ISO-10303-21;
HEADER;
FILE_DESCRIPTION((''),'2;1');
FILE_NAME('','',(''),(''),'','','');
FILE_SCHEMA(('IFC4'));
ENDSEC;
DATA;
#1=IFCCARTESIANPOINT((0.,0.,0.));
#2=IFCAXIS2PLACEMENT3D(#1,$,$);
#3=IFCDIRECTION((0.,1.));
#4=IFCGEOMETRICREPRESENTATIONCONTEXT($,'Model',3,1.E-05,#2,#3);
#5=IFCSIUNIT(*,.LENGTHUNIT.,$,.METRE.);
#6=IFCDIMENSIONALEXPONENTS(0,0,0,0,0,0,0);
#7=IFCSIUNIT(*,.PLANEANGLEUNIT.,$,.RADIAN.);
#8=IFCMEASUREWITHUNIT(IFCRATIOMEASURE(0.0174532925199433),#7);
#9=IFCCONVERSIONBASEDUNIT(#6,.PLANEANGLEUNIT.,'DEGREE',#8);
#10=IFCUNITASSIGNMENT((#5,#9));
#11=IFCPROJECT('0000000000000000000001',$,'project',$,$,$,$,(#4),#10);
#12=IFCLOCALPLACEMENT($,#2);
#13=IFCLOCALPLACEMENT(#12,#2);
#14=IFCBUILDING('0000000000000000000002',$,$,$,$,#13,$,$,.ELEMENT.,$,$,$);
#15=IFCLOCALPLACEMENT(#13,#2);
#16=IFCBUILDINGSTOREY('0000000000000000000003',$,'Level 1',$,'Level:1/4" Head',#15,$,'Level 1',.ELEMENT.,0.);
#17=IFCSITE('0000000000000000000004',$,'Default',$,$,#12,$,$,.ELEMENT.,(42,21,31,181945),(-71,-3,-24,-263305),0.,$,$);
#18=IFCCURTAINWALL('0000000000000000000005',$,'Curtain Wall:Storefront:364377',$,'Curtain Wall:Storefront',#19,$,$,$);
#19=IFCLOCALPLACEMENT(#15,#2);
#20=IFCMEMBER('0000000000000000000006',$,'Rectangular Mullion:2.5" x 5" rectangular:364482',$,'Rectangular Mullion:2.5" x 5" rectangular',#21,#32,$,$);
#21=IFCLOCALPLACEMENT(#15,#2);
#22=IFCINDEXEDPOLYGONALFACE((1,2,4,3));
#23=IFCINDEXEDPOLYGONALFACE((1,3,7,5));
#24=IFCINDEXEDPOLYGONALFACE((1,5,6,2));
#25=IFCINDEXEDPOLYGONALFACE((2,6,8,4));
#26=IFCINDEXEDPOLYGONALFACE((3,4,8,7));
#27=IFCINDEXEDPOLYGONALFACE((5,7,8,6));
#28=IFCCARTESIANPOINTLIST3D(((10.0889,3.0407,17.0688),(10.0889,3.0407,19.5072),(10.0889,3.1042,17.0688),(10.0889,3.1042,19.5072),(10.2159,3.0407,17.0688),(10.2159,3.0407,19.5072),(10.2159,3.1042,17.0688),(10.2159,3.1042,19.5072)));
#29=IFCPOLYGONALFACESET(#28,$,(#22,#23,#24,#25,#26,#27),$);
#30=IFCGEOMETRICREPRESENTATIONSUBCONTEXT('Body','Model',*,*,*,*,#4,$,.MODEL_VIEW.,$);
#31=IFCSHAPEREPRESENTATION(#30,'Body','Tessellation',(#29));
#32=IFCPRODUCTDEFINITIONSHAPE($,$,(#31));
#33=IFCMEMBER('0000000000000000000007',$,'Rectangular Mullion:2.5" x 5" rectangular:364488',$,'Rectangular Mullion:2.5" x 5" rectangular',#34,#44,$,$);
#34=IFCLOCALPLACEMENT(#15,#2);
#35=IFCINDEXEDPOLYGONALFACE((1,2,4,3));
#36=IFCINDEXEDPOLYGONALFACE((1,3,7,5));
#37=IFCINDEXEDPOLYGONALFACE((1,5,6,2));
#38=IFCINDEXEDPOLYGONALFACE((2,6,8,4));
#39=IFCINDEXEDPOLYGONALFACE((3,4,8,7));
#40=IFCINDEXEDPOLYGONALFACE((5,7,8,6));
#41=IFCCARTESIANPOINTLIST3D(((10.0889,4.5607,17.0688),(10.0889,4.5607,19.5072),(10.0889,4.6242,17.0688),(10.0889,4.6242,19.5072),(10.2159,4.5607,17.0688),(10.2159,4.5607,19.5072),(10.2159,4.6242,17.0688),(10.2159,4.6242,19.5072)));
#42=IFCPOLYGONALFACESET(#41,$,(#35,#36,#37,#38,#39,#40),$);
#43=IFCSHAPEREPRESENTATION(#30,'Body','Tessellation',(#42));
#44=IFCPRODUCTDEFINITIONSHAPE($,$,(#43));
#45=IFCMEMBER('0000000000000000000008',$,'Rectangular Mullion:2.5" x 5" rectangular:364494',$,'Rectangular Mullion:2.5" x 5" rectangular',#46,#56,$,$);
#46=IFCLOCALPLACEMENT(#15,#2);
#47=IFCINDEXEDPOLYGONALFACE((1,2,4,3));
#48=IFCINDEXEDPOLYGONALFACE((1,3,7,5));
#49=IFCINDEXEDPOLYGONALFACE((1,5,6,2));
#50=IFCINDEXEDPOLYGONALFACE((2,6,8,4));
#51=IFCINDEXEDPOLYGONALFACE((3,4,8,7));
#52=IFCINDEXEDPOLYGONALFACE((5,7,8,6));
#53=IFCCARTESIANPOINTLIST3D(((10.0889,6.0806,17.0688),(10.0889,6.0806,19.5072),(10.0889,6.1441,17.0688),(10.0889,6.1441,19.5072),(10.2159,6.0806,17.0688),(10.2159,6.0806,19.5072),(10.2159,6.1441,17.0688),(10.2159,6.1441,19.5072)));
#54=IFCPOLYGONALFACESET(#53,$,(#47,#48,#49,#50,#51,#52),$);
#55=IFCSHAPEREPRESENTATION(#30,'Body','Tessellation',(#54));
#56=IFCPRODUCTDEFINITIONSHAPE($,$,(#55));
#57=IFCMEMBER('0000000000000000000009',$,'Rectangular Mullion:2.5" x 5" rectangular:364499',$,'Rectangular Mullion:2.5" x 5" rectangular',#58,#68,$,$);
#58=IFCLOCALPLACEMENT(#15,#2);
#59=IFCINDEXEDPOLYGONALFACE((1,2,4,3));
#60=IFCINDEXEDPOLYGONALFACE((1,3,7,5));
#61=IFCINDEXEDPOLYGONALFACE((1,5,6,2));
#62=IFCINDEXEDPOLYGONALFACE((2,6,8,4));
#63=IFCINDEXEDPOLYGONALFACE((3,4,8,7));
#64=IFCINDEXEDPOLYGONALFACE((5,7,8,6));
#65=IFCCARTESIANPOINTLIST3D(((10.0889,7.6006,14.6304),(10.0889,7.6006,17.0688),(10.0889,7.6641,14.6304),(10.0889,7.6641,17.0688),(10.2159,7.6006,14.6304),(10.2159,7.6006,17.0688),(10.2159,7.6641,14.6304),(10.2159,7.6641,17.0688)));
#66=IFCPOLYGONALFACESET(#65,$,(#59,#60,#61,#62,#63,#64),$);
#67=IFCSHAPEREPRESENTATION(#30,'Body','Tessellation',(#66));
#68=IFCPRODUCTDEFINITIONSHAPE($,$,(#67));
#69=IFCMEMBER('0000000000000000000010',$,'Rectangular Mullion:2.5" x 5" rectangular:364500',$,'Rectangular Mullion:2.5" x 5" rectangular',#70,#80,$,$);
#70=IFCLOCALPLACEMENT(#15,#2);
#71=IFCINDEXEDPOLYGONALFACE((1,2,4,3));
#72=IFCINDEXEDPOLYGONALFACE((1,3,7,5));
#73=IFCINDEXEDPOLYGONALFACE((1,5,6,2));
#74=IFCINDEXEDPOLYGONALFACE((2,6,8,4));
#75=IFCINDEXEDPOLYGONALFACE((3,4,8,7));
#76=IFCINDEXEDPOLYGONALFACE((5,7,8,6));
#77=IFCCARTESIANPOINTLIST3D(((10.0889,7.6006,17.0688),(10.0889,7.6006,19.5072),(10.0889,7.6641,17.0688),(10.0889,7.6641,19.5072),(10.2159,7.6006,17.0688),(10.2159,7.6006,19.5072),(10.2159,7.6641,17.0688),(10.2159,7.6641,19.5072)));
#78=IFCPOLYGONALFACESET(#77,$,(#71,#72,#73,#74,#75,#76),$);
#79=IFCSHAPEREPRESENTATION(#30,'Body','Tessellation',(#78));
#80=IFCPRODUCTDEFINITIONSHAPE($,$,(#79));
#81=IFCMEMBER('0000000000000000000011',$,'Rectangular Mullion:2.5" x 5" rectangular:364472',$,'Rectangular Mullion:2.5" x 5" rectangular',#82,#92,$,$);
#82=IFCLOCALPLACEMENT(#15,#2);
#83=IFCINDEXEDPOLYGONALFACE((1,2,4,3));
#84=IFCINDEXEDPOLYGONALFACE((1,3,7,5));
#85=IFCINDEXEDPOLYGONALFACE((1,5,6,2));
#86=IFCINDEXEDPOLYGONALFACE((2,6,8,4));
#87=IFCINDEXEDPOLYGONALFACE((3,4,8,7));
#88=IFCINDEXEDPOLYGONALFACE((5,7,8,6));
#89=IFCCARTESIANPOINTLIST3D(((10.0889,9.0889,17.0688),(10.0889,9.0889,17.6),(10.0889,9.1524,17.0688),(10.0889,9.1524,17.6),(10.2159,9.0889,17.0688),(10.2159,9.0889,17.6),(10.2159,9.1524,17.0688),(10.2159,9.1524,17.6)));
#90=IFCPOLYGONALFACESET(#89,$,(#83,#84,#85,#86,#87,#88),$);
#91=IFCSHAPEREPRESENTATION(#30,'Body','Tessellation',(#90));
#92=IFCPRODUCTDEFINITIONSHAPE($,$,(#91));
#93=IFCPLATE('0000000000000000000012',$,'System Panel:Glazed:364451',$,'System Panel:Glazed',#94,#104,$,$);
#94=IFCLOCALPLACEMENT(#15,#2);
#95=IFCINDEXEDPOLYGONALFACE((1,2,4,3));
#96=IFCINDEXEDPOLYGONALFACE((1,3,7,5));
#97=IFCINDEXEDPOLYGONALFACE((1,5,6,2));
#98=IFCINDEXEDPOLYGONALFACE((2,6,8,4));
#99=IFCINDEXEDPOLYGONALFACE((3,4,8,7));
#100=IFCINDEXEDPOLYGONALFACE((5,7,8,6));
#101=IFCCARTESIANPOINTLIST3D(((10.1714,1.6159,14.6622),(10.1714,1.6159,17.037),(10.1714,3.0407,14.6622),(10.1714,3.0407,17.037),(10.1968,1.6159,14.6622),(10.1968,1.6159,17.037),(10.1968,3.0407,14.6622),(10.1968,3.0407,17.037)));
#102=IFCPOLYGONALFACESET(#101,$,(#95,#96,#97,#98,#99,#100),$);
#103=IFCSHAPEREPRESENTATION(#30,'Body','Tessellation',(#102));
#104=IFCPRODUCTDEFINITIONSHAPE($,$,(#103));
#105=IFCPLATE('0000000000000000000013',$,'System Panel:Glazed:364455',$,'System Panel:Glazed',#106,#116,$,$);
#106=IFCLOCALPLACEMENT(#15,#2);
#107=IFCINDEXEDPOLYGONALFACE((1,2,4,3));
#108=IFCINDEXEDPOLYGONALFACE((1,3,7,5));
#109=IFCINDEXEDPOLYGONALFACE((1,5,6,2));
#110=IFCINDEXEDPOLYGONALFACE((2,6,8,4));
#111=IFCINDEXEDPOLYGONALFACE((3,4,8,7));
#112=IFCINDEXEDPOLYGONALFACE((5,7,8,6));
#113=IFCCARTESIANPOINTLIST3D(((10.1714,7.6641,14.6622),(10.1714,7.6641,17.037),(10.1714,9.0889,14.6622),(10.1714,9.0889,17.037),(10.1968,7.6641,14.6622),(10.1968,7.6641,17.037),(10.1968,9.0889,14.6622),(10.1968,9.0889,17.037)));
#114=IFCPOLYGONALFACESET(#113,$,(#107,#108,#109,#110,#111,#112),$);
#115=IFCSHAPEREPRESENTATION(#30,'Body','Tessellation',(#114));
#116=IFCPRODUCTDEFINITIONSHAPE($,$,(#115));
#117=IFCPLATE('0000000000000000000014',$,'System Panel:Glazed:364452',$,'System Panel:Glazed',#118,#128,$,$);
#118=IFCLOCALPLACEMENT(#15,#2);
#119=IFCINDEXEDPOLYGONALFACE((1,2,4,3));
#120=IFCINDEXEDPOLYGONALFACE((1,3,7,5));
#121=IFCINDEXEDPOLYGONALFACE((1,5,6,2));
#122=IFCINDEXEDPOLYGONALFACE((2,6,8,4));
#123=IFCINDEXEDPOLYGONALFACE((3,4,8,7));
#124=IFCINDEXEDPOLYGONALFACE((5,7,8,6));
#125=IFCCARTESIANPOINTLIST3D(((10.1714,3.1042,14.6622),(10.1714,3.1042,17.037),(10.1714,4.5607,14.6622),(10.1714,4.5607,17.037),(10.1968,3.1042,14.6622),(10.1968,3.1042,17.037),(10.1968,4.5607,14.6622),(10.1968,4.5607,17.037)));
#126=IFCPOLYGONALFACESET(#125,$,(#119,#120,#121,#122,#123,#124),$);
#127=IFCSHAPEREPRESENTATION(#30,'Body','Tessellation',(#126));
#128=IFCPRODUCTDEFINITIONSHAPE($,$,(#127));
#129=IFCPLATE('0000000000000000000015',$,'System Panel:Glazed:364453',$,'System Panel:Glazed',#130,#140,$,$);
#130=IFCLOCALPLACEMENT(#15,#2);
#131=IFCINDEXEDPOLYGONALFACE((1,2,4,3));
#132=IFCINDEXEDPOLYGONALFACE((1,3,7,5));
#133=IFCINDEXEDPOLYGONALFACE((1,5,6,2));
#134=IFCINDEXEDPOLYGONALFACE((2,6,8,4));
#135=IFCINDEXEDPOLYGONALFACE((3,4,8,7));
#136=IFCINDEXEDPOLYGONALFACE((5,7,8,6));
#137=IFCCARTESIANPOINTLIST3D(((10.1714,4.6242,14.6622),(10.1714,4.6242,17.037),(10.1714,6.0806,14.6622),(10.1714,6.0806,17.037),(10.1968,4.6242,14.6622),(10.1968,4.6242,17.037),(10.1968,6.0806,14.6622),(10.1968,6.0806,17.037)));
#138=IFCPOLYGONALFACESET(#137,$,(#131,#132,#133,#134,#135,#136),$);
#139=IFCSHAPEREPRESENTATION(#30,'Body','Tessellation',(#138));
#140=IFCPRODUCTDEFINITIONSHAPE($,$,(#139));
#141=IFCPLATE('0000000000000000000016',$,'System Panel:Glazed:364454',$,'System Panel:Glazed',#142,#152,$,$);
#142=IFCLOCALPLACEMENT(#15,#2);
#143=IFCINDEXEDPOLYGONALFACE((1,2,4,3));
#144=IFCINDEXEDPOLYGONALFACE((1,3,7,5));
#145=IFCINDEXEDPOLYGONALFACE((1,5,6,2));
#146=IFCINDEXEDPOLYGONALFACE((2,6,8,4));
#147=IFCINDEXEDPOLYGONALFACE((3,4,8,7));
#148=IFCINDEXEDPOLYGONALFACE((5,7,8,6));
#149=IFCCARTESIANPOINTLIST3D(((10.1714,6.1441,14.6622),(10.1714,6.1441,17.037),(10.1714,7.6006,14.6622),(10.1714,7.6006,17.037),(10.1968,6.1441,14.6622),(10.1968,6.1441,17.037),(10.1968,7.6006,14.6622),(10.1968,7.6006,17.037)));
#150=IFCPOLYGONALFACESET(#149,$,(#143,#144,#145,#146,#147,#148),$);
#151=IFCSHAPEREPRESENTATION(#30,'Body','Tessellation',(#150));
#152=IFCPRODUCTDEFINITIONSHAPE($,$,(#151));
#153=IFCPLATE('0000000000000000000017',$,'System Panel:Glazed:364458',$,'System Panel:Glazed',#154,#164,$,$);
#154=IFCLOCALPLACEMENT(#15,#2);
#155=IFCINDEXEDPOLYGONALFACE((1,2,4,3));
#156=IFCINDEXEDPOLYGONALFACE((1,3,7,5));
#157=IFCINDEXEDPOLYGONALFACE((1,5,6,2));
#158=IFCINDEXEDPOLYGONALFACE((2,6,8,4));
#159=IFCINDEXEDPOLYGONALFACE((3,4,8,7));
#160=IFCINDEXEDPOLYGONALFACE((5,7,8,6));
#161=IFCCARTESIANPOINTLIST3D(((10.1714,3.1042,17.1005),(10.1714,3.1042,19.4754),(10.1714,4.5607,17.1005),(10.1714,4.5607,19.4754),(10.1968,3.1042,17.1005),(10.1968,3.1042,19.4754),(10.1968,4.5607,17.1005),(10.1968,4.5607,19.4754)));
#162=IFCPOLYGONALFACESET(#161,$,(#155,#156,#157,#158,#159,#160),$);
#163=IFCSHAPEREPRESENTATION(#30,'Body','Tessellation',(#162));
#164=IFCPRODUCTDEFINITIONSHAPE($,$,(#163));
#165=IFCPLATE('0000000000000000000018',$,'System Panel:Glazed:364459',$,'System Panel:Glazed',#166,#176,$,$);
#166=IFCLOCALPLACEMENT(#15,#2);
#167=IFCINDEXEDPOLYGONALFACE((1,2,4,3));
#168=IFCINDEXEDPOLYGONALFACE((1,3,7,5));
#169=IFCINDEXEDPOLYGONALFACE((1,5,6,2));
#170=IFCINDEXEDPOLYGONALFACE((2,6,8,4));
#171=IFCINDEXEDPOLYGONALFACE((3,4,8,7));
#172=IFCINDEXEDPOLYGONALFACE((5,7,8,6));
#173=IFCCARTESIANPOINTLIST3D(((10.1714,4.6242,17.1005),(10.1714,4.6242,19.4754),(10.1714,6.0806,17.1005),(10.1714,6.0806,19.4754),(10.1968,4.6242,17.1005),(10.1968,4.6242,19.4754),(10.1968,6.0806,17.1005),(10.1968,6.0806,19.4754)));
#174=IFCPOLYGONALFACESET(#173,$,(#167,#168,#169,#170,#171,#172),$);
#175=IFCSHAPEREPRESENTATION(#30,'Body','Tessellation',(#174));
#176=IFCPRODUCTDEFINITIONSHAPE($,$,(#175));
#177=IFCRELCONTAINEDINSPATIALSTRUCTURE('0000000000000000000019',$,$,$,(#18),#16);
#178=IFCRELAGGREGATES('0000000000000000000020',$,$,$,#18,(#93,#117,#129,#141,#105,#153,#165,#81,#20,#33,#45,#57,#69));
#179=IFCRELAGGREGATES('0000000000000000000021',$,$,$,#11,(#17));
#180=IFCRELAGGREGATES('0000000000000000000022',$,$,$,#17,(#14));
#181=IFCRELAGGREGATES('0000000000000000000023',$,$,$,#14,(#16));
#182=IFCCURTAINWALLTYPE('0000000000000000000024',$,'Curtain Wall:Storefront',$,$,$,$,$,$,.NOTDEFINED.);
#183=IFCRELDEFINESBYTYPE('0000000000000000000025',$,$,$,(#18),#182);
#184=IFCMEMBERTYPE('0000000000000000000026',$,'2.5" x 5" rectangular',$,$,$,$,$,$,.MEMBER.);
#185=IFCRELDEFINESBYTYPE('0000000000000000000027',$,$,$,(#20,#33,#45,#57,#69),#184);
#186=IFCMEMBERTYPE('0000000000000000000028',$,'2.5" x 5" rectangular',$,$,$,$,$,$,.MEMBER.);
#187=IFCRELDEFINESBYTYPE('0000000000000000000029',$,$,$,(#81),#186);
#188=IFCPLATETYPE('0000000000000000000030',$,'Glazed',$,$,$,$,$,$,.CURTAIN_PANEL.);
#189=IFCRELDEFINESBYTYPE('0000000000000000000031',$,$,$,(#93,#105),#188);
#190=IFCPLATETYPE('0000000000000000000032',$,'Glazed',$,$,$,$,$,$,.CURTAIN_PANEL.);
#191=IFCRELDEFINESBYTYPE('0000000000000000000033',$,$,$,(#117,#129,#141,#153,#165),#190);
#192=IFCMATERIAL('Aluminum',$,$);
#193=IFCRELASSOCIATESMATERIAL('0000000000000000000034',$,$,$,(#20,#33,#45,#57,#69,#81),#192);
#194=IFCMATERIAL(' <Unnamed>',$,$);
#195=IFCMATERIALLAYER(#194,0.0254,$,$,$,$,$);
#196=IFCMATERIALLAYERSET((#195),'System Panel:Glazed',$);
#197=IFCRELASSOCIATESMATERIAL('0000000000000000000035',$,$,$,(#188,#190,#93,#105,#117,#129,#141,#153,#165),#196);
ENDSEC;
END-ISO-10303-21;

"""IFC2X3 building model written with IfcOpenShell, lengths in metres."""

from ifc_helpers import new_model, entity, si_unit, converted_unit, direction, frame, frame_2d, origin, origin_2d_with_axis, place, context, subcontext, project, spatial, rectangle, extrude, source, transform, mapped, material, layer, layer_set, layer_usage, type_object, type_shapes, element, aggregate, save


model = new_model("IFC2X3")

# Units and contexts
model_context = context("Model", 3, precision=1e-05, world=origin(), true_north=direction((0.0, 1.0)))
body_context = subcontext(model_context, "Body", "Model", "MODEL_VIEW")
ifc_project = project(units=[si_unit("LENGTHUNIT", "METRE"), converted_unit("PLANEANGLEUNIT", "DEGREE", entity("IfcRatioMeasure", 0.0174532925199433), si_unit("PLANEANGLEUNIT", "RADIAN"), dimensions=[0, 0, 0, 0, 0, 0, 0])], contexts=[model_context])

# Site, building, storey
site_placement = place(None, origin())
site = spatial("IfcSite", under=ifc_project, at=site_placement, Name="Default", CompositionType="ELEMENT", RefLatitude=(42, 21, 31, 181945), RefLongitude=(-71, -3, -24, -263305), RefElevation=0.0)
building_placement = place(site_placement, origin())
building = spatial("IfcBuilding", under=site, at=building_placement, CompositionType="ELEMENT")
storey_placement = place(building_placement, origin())
storey = spatial("IfcBuildingStorey", under=building, at=storey_placement, Name="Level 1", ObjectType="Level:1/4\" Head", LongName="Level 1", CompositionType="ELEMENT", Elevation=0.0)

# Curtain wall, members, plates
curtain_wall_type = type_object("IfcCurtainWallType", Name="Curtain Wall:Storefront", PredefinedType="NOTDEFINED")
curtain_wall_placement = place(storey_placement, origin())
curtain_wall = element("IfcCurtainWall", 1, at=curtain_wall_placement, inside=storey, type_object=curtain_wall_type, Name="Curtain Wall:Storefront:364377", ObjectType="Curtain Wall:Storefront")
ifc_material_1 = material(Name="Aluminum")
member_type_1 = type_object("IfcMemberType", Name="2.5\" x 5\" rectangular", PredefinedType="MEMBER")
shared_shape_1 = source(origin(), body_context, "Body", "SweptSolid", [
    extrude(rectangle(XDim=0.127, YDim=0.0635, at=origin_2d_with_axis()), frame((0.0, 0.0, -2.4384), z_axis=(0.0, 0.0, 1.0), x_axis=(0.0, -1.0, 0.0)), (0.0, 0.0, 1.0), 2.4384),
])
type_shapes(member_type_1, [shared_shape_1])
member_1_placement = place(storey_placement, frame((10.1524, 3.0724, 17.0688), z_axis=(0.0, 0.0, -1.0), x_axis=(0.0, 1.0, 0.0)))
member_1 = element("IfcMember", 2, at=member_1_placement, type_object=member_type_1, material=ifc_material_1, Name="Rectangular Mullion:2.5\" x 5\" rectangular:364482", ObjectType="Rectangular Mullion:2.5\" x 5\" rectangular", context=body_context, shape_type="MappedRepresentation", body=[
    mapped(shared_shape_1, transform((0.0, 0.0, 0.0), scale=1.0)),
])
member_2_placement = place(storey_placement, frame((10.1524, 4.5924, 17.0688), z_axis=(0.0, 0.0, -1.0), x_axis=(0.0, 1.0, 0.0)))
member_2 = element("IfcMember", 3, at=member_2_placement, type_object=member_type_1, material=ifc_material_1, Name="Rectangular Mullion:2.5\" x 5\" rectangular:364488", ObjectType="Rectangular Mullion:2.5\" x 5\" rectangular", context=body_context, shape_type="MappedRepresentation", body=[
    mapped(shared_shape_1, transform((0.0, 0.0, 0.0), scale=1.0)),
])
member_3_placement = place(storey_placement, frame((10.1524, 6.1124, 17.0688), z_axis=(0.0, 0.0, -1.0), x_axis=(0.0, 1.0, 0.0)))
member_3 = element("IfcMember", 4, at=member_3_placement, type_object=member_type_1, material=ifc_material_1, Name="Rectangular Mullion:2.5\" x 5\" rectangular:364494", ObjectType="Rectangular Mullion:2.5\" x 5\" rectangular", context=body_context, shape_type="MappedRepresentation", body=[
    mapped(shared_shape_1, transform((0.0, 0.0, 0.0), scale=1.0)),
])
member_4_placement = place(storey_placement, frame((10.1524, 7.6324, 14.6304), z_axis=(0.0, 0.0, -1.0), x_axis=(0.0, 1.0, 0.0)))
member_4 = element("IfcMember", 5, at=member_4_placement, type_object=member_type_1, material=ifc_material_1, Name="Rectangular Mullion:2.5\" x 5\" rectangular:364499", ObjectType="Rectangular Mullion:2.5\" x 5\" rectangular", context=body_context, shape_type="MappedRepresentation", body=[
    mapped(shared_shape_1, transform((0.0, 0.0, 0.0), scale=1.0)),
])
member_5_placement = place(storey_placement, frame((10.1524, 7.6324, 17.0688), z_axis=(0.0, 0.0, -1.0), x_axis=(0.0, 1.0, 0.0)))
member_5 = element("IfcMember", 6, at=member_5_placement, type_object=member_type_1, material=ifc_material_1, Name="Rectangular Mullion:2.5\" x 5\" rectangular:364500", ObjectType="Rectangular Mullion:2.5\" x 5\" rectangular", context=body_context, shape_type="MappedRepresentation", body=[
    mapped(shared_shape_1, transform((0.0, 0.0, 0.0), scale=1.0)),
])
member_type_2 = type_object("IfcMemberType", Name="2.5\" x 5\" rectangular", PredefinedType="MEMBER")
shared_shape_2 = source(origin(), body_context, "Body", "SweptSolid", [
    extrude(rectangle(XDim=0.127, YDim=0.0635, at=origin_2d_with_axis()), frame((-0.0318, 0.0, -0.5312), z_axis=(0.0, 0.0, 1.0), x_axis=(0.0, -1.0, 0.0)), (0.0, 0.0, 1.0), 0.5312),
])
type_shapes(member_type_2, [shared_shape_2])
member_6_placement = place(storey_placement, frame((10.1524, 9.1524, 17.0688), z_axis=(0.0, 0.0, -1.0), x_axis=(0.0, 1.0, 0.0)))
member_6 = element("IfcMember", 7, at=member_6_placement, type_object=member_type_2, material=ifc_material_1, Name="Rectangular Mullion:2.5\" x 5\" rectangular:364472", ObjectType="Rectangular Mullion:2.5\" x 5\" rectangular", context=body_context, shape_type="MappedRepresentation", body=[
    mapped(shared_shape_2, transform((0.0, 0.0, 0.0), scale=1.0)),
])
ifc_material_2 = material(Name=" <Unnamed>")
ifc_layer = layer(ifc_material_2, 0.0254)
ifc_layer_set = layer_set([ifc_layer], Name="System Panel:Glazed")
ifc_layer_usage_1 = layer_usage(ifc_layer_set, "AXIS3", "POSITIVE", 0.1042)
plate_type_1 = type_object("IfcPlateType", Name="Glazed", PredefinedType="CURTAIN_PANEL", material=ifc_layer_set)
shared_shape_3 = source(origin(), body_context, "Body", "SweptSolid", [
    extrude(rectangle(XDim=0.0254, YDim=1.4248, at=frame_2d((0.0, 0.0), x_axis=(1.0, 0.0))), frame((0.7124, 0.0127, 0.0), z_axis=(0.0, 0.0, 1.0), x_axis=(0.0, 1.0, 0.0)), (0.0, 0.0, 1.0), 2.3749),
])
type_shapes(plate_type_1, [shared_shape_3])
plate_1_placement = place(curtain_wall_placement, frame((10.1968, 1.6159, 14.6622), z_axis=(0.0, 0.0, 1.0), x_axis=(0.0, 1.0, 0.0)))
plate_1 = element("IfcPlate", 8, at=plate_1_placement, type_object=plate_type_1, material=ifc_layer_usage_1, Name="System Panel:Glazed:364451", ObjectType="System Panel:Glazed", context=body_context, shape_type="MappedRepresentation", body=[
    mapped(shared_shape_3, transform((0.0, 0.0, 0.0), scale=1.0)),
])
ifc_layer_usage_2 = layer_usage(ifc_layer_set, "AXIS3", "POSITIVE", 0.1042)
plate_2_placement = place(curtain_wall_placement, frame((10.1968, 7.6641, 14.6622), z_axis=(0.0, 0.0, 1.0), x_axis=(0.0, 1.0, 0.0)))
plate_2 = element("IfcPlate", 9, at=plate_2_placement, type_object=plate_type_1, material=ifc_layer_usage_2, Name="System Panel:Glazed:364455", ObjectType="System Panel:Glazed", context=body_context, shape_type="MappedRepresentation", body=[
    mapped(shared_shape_3, transform((0.0, 0.0, 0.0), scale=1.0)),
])
ifc_layer_usage_3 = layer_usage(ifc_layer_set, "AXIS3", "POSITIVE", 0.1042)
plate_type_2 = type_object("IfcPlateType", Name="Glazed", PredefinedType="CURTAIN_PANEL", material=ifc_layer_set)
shared_shape_4 = source(origin(), body_context, "Body", "SweptSolid", [
    extrude(rectangle(XDim=0.0254, YDim=1.4565, at=origin_2d_with_axis()), frame((0.7282, 0.0127, 0.0), z_axis=(0.0, 0.0, 1.0), x_axis=(0.0, 1.0, 0.0)), (0.0, 0.0, 1.0), 2.3749),
])
type_shapes(plate_type_2, [shared_shape_4])
plate_3_placement = place(curtain_wall_placement, frame((10.1968, 3.1042, 14.6622), z_axis=(0.0, 0.0, 1.0), x_axis=(0.0, 1.0, 0.0)))
plate_3 = element("IfcPlate", 10, at=plate_3_placement, type_object=plate_type_2, material=ifc_layer_usage_3, Name="System Panel:Glazed:364452", ObjectType="System Panel:Glazed", context=body_context, shape_type="MappedRepresentation", body=[
    mapped(shared_shape_4, transform((0.0, 0.0, 0.0), scale=1.0)),
])
ifc_layer_usage_4 = layer_usage(ifc_layer_set, "AXIS3", "POSITIVE", 0.1042)
plate_4_placement = place(curtain_wall_placement, frame((10.1968, 4.6242, 14.6622), z_axis=(0.0, 0.0, 1.0), x_axis=(0.0, 1.0, 0.0)))
plate_4 = element("IfcPlate", 11, at=plate_4_placement, type_object=plate_type_2, material=ifc_layer_usage_4, Name="System Panel:Glazed:364453", ObjectType="System Panel:Glazed", context=body_context, shape_type="MappedRepresentation", body=[
    mapped(shared_shape_4, transform((0.0, 0.0, 0.0), scale=1.0)),
])
ifc_layer_usage_5 = layer_usage(ifc_layer_set, "AXIS3", "POSITIVE", 0.1042)
plate_5_placement = place(curtain_wall_placement, frame((10.1968, 6.1441, 14.6622), z_axis=(0.0, 0.0, 1.0), x_axis=(0.0, 1.0, 0.0)))
plate_5 = element("IfcPlate", 12, at=plate_5_placement, type_object=plate_type_2, material=ifc_layer_usage_5, Name="System Panel:Glazed:364454", ObjectType="System Panel:Glazed", context=body_context, shape_type="MappedRepresentation", body=[
    mapped(shared_shape_4, transform((0.0, 0.0, 0.0), scale=1.0)),
])
ifc_layer_usage_6 = layer_usage(ifc_layer_set, "AXIS3", "POSITIVE", 0.1042)
plate_6_placement = place(curtain_wall_placement, frame((10.1968, 3.1042, 17.1005), z_axis=(0.0, 0.0, 1.0), x_axis=(0.0, 1.0, 0.0)))
plate_6 = element("IfcPlate", 13, at=plate_6_placement, type_object=plate_type_2, material=ifc_layer_usage_6, Name="System Panel:Glazed:364458", ObjectType="System Panel:Glazed", context=body_context, shape_type="MappedRepresentation", body=[
    mapped(shared_shape_4, transform((0.0, 0.0, 0.0), scale=1.0)),
])
ifc_layer_usage_7 = layer_usage(ifc_layer_set, "AXIS3", "POSITIVE", 0.1042)
plate_7_placement = place(curtain_wall_placement, frame((10.1968, 4.6242, 17.1005), z_axis=(0.0, 0.0, 1.0), x_axis=(0.0, 1.0, 0.0)))
plate_7 = element("IfcPlate", 14, at=plate_7_placement, type_object=plate_type_2, material=ifc_layer_usage_7, Name="System Panel:Glazed:364459", ObjectType="System Panel:Glazed", context=body_context, shape_type="MappedRepresentation", body=[
    mapped(shared_shape_4, transform((0.0, 0.0, 0.0), scale=1.0)),
])
aggregate(curtain_wall, [plate_1, plate_3, plate_4, plate_5, plate_2, plate_6, plate_7, member_6, member_1, member_2, member_3, member_4, member_5])

save(model, "model.ifc")
